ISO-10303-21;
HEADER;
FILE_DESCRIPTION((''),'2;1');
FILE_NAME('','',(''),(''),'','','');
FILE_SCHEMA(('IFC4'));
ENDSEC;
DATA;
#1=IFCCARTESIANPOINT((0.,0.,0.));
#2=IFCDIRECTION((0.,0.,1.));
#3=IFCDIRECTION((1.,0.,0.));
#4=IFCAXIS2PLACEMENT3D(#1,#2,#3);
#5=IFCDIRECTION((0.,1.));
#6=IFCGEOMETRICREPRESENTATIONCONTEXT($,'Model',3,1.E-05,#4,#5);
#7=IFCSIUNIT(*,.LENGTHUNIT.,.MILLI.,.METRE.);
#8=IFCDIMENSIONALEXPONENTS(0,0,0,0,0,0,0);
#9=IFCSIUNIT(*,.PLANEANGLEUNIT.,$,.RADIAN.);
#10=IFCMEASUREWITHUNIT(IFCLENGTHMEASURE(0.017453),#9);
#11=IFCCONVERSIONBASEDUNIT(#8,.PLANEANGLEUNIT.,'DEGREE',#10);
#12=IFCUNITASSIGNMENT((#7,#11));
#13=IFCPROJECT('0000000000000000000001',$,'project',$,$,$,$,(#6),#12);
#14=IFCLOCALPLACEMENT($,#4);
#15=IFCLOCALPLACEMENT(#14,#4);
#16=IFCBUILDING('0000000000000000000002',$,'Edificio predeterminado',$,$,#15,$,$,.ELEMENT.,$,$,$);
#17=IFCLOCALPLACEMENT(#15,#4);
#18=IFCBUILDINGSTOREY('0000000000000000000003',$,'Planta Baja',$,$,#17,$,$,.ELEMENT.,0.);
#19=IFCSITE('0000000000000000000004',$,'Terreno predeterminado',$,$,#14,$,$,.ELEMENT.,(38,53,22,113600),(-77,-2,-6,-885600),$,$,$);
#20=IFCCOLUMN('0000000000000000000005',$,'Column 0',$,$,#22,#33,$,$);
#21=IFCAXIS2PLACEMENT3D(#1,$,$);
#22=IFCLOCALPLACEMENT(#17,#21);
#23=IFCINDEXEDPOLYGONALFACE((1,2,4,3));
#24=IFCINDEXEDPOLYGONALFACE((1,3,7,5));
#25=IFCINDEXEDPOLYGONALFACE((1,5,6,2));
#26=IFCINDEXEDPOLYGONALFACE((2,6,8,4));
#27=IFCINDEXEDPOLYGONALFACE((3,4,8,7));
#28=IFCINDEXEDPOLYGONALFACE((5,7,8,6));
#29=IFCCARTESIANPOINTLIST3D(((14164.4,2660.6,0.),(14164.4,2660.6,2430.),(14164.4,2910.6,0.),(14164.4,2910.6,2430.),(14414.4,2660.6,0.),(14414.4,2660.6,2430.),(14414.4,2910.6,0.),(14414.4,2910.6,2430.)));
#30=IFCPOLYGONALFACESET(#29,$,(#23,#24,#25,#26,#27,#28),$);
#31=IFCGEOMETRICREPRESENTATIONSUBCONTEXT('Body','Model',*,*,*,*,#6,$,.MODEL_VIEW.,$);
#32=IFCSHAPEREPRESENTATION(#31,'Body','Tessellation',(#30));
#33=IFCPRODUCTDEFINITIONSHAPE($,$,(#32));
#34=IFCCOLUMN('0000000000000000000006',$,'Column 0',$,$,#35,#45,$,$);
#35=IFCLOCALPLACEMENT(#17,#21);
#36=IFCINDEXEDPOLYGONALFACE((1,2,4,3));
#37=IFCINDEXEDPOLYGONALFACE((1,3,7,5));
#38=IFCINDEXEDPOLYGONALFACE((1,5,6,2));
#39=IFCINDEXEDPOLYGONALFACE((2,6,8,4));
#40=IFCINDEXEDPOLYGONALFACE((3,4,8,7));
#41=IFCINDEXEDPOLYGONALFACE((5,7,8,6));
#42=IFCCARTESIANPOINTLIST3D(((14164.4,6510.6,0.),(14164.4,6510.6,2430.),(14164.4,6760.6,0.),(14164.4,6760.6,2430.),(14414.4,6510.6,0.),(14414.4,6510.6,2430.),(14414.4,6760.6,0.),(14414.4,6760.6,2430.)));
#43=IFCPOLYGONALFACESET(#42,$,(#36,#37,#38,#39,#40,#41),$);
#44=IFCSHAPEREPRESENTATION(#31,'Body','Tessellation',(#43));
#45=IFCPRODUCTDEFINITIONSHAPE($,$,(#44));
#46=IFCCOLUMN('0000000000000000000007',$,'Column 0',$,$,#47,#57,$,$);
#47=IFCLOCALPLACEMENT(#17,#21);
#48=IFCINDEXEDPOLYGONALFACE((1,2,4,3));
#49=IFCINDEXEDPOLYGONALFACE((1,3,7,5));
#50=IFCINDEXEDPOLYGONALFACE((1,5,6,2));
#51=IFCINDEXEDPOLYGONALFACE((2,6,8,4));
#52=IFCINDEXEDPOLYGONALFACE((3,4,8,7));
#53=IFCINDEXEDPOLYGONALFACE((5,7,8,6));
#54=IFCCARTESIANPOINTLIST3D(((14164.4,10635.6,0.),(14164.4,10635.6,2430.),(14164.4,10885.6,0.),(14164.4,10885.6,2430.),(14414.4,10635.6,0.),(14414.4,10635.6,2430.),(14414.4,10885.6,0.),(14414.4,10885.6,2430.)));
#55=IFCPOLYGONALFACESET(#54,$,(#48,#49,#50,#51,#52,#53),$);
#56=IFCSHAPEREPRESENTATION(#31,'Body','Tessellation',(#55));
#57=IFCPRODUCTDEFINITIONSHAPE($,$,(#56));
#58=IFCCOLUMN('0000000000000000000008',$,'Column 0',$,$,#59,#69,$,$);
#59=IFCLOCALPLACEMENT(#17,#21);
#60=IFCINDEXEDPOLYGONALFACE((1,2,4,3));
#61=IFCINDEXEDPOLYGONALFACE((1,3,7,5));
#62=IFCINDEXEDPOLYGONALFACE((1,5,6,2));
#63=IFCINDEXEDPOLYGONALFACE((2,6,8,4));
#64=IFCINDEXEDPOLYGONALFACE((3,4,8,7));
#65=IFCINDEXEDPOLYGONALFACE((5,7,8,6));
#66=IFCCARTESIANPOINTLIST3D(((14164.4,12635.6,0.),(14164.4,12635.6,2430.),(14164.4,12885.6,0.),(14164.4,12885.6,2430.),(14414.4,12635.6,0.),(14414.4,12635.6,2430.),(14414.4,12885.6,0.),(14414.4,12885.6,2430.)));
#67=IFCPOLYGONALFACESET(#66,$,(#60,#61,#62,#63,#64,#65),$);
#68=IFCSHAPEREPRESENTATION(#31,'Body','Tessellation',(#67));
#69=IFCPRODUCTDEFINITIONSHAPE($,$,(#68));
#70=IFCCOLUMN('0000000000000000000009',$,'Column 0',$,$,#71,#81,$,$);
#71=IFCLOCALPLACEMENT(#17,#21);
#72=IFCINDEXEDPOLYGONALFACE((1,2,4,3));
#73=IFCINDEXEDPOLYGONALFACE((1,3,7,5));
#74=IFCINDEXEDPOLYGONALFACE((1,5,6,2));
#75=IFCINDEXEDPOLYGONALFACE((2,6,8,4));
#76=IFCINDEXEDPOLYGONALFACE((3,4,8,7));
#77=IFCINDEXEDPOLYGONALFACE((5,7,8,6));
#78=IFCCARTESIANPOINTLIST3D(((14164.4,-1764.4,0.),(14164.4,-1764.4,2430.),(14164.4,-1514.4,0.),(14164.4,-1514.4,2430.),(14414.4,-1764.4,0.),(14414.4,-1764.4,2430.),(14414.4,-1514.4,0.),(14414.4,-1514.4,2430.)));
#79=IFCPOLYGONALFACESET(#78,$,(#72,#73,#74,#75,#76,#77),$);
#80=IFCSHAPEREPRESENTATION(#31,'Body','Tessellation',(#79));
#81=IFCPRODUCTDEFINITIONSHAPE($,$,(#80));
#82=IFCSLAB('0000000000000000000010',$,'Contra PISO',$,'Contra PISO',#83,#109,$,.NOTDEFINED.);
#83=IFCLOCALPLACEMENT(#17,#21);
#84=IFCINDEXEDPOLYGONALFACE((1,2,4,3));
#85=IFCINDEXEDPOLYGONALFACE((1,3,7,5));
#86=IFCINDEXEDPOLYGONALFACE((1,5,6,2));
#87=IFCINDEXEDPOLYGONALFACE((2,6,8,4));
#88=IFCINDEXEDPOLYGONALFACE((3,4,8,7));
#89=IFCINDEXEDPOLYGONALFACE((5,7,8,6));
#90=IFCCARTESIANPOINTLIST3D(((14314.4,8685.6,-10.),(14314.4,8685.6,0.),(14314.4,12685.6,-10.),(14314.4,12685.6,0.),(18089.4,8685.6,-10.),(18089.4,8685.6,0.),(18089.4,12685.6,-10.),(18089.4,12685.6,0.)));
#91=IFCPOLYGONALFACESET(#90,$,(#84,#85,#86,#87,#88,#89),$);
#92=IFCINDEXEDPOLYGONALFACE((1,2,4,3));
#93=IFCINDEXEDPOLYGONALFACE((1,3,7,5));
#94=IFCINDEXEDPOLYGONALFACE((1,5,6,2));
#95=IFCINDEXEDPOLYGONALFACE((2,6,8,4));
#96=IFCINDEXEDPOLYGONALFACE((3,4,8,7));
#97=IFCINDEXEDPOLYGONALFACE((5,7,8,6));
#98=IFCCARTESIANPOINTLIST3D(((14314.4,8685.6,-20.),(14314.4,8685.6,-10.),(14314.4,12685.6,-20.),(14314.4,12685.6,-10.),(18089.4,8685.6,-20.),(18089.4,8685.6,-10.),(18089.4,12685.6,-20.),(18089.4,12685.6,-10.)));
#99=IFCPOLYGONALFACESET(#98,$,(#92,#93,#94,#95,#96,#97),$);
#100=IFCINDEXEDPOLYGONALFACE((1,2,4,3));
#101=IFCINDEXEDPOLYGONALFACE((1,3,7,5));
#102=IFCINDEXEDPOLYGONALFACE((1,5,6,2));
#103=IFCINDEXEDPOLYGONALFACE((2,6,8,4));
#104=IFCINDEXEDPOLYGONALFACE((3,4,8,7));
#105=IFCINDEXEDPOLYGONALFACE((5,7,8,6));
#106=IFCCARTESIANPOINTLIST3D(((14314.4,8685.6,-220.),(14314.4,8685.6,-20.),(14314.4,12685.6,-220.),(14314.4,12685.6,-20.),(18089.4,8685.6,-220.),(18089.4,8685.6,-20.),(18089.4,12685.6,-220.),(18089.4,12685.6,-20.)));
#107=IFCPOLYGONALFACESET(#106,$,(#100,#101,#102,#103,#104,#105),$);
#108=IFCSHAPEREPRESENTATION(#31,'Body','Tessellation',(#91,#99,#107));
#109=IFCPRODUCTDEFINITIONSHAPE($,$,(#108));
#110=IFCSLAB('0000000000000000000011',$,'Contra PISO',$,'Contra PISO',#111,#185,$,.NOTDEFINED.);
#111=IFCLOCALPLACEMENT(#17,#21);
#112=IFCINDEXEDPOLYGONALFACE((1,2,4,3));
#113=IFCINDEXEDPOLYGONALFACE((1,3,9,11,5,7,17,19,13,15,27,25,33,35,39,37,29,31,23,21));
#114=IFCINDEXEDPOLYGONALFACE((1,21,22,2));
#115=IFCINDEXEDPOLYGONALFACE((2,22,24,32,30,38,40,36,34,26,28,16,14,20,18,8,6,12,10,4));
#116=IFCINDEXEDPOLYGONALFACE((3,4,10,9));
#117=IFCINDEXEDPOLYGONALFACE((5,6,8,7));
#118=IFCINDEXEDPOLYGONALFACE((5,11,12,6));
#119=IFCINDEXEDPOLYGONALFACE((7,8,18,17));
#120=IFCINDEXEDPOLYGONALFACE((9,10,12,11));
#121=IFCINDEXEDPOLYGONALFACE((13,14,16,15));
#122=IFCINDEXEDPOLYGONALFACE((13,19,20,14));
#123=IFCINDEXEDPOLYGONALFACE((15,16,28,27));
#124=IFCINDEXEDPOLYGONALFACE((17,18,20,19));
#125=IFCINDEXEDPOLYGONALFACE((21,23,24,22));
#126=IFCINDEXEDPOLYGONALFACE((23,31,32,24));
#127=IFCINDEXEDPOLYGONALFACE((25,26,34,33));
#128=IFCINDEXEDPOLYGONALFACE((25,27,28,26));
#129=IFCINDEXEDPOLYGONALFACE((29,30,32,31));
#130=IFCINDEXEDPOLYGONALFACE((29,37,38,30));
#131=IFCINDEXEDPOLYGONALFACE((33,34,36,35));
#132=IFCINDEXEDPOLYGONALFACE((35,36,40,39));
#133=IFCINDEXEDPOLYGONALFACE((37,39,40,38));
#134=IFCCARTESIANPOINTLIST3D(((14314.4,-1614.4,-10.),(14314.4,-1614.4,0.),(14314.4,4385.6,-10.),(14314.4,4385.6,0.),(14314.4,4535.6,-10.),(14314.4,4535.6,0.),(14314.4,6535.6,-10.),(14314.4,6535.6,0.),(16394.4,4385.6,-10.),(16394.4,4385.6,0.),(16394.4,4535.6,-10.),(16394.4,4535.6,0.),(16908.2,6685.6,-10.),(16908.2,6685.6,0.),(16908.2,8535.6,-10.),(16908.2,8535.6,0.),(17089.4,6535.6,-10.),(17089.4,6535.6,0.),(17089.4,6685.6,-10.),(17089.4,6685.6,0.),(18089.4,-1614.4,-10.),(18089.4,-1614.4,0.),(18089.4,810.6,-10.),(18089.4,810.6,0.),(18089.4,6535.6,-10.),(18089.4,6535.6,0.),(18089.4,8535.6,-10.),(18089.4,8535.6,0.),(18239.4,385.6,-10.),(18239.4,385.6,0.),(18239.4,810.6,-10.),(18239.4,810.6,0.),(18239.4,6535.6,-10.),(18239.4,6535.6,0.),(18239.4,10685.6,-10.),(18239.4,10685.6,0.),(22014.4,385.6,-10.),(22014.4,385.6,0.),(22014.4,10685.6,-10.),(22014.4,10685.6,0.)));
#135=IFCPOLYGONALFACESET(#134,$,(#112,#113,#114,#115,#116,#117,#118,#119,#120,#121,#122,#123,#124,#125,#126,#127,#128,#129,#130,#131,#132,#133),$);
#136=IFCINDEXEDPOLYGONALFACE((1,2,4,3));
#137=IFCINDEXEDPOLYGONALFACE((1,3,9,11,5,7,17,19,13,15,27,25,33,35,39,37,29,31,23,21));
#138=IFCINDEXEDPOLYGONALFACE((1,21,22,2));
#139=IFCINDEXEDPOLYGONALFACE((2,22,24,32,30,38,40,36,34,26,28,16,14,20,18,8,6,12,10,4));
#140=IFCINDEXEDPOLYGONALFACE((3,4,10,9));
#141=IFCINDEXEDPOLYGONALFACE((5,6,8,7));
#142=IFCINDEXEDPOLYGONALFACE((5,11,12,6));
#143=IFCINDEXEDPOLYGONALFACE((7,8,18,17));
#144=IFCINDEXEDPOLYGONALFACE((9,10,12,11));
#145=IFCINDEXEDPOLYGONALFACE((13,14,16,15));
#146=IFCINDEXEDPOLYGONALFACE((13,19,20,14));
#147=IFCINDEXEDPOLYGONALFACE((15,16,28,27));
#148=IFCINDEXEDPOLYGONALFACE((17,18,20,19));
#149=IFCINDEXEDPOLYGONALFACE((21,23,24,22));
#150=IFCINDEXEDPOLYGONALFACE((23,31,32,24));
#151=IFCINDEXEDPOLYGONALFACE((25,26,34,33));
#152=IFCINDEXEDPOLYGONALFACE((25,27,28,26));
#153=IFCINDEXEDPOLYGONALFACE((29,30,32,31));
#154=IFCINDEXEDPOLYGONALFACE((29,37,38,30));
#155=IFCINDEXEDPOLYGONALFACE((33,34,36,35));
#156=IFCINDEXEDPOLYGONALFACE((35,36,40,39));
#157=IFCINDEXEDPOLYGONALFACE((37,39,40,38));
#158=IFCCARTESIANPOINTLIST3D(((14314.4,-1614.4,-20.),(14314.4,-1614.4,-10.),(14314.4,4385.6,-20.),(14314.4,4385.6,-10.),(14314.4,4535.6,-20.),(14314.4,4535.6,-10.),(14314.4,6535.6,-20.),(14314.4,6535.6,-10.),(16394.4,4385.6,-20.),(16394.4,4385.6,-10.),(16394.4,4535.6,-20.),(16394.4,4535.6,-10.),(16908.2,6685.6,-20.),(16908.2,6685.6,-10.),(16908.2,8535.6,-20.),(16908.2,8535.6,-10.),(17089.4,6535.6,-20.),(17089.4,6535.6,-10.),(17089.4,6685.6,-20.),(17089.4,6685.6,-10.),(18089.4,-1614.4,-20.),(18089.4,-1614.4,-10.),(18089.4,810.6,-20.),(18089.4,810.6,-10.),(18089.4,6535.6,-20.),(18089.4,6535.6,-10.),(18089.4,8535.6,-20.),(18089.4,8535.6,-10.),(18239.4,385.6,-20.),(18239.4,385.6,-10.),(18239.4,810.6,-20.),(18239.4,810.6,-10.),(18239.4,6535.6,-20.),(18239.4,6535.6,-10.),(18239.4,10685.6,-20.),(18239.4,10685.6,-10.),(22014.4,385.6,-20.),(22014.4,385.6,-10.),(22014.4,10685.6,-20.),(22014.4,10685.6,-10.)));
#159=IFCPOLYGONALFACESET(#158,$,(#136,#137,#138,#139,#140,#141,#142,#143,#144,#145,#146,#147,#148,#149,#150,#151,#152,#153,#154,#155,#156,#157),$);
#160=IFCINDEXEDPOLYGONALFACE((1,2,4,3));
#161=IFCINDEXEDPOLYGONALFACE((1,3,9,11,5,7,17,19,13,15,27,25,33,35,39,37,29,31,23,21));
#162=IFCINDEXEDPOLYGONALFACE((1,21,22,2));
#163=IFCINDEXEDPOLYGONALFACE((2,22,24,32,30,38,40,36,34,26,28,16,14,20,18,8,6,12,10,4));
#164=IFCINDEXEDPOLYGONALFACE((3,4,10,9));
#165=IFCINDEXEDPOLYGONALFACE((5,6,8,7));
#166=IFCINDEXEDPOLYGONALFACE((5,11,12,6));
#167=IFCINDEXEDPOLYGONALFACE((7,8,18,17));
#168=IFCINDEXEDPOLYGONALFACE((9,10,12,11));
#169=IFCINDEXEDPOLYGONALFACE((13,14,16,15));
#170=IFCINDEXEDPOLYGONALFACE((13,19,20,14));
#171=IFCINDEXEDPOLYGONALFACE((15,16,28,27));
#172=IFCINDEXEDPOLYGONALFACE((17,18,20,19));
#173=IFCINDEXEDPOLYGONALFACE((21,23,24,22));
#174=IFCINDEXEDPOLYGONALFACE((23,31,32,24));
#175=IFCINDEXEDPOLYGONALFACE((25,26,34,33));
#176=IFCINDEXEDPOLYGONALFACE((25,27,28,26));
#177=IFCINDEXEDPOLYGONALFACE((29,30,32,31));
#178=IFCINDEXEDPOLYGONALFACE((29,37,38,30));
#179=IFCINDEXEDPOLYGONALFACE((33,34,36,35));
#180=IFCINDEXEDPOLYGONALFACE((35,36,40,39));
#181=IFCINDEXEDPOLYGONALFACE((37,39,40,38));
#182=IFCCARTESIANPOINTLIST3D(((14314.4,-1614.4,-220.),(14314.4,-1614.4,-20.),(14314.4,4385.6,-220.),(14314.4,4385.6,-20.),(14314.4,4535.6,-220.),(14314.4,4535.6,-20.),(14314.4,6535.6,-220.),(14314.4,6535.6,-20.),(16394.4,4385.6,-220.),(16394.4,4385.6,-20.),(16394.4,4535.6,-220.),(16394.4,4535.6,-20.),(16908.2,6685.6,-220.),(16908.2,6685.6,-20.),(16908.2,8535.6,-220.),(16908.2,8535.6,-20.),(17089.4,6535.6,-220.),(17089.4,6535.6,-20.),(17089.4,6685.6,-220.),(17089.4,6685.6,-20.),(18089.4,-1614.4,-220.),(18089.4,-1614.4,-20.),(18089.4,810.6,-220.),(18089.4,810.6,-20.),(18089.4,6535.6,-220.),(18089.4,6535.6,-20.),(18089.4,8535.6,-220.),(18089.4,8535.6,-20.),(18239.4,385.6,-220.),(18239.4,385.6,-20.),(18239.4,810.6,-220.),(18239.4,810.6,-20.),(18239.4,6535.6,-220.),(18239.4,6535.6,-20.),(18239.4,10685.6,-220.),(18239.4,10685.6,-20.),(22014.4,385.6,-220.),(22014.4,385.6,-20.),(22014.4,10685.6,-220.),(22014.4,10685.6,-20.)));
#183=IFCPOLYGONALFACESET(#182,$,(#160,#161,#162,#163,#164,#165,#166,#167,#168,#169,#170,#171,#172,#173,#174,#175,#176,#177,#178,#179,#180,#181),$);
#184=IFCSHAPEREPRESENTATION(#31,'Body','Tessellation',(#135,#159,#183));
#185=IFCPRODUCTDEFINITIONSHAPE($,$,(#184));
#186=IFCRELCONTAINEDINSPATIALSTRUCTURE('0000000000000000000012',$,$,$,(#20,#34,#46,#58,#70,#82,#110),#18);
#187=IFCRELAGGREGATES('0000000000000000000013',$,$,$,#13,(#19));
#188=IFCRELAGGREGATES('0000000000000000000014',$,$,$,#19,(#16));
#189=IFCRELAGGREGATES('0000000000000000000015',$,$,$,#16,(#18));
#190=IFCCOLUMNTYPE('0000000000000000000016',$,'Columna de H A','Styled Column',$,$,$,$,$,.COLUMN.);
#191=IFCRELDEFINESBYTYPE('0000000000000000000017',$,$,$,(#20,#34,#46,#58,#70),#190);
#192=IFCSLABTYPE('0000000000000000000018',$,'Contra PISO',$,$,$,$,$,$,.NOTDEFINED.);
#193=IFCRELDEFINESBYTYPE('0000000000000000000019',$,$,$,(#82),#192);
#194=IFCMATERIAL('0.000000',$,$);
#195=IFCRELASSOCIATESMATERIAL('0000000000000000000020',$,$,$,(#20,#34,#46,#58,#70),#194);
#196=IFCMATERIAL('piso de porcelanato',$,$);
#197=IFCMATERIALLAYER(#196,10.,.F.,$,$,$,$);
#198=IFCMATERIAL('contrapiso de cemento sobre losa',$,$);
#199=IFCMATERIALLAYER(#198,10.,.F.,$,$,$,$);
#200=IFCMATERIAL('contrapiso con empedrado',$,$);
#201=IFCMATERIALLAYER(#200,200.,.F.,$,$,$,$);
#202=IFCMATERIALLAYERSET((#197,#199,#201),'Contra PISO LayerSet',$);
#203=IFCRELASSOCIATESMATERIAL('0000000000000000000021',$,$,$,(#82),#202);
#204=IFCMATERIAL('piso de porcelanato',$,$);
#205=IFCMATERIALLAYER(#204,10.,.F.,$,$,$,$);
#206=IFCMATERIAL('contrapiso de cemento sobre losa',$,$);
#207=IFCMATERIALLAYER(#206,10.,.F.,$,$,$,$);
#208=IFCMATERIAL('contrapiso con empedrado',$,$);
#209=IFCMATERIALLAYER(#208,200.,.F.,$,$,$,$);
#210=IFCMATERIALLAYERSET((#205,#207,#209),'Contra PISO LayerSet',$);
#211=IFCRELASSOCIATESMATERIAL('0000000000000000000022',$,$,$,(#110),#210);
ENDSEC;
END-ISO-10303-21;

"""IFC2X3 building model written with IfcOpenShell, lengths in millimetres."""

from ifc_helpers import new_model, entity, si_unit, converted_unit, direction, frame, origin_with_axes, place, context, subcontext, project, spatial, polyline, outline, extrude, material, layer, layer_set, layer_usage, type_object, element, save


model = new_model("IFC2X3")

# Units and contexts
model_context = context("Model", 3, precision=1e-05, world=origin_with_axes(), true_north=direction((0.0, 1.0)))
body_context = subcontext(model_context, "Body", "Model", "MODEL_VIEW")
ifc_project = project(units=[si_unit("LENGTHUNIT", "METRE", prefix="MILLI"), converted_unit("PLANEANGLEUNIT", "DEGREE", entity("IfcLengthMeasure", 0.017453), si_unit("PLANEANGLEUNIT", "RADIAN"), dimensions=[0, 0, 0, 0, 0, 0, 0])], contexts=[model_context])

# Site, building, storey
site_placement = place(None, origin_with_axes())
site = spatial("IfcSite", under=ifc_project, at=site_placement, Name="Terreno predeterminado", CompositionType="ELEMENT", RefLatitude=(38, 53, 22, 113600), RefLongitude=(-77, -2, -6, -885600))
building_placement = place(site_placement, origin_with_axes())
building = spatial("IfcBuilding", under=site, at=building_placement, Name="Edificio predeterminado", CompositionType="ELEMENT")
storey_placement = place(building_placement, origin_with_axes())
storey = spatial("IfcBuildingStorey", under=building, at=storey_placement, Name="Planta Baja", CompositionType="ELEMENT", Elevation=0.0)

# Columns
ifc_material_1 = material(Name="0.000000")
column_type = type_object("IfcColumnType", Name="Columna de H A", Description="Styled Column", PredefinedType="COLUMN")
for number, where, z_axis, x_axis, name in (
    (1, (14289.4, 2785.6, 0.0), (0.0, 0.0, 1.0), (1.0, 0.0, 0.0), "Column 0"),
    (2, (14289.4, 6635.6, 0.0), (0.0, 0.0, 1.0), (1.0, 0.0, 0.0), "Column 0"),
    (3, (14289.4, 10760.6, 0.0), (0.0, 0.0, 1.0), (1.0, 0.0, 0.0), "Column 0"),
    (4, (14289.4, 12760.6, 0.0), (0.0, 0.0, 1.0), (1.0, 0.0, 0.0), "Column 0"),
    (5, (14289.4, -1639.4, 0.0), (0.0, 0.0, 1.0), (1.0, 0.0, 0.0), "Column 0"),
):
    element("IfcColumn", number, at=place(storey_placement, frame(where, z_axis=z_axis, x_axis=x_axis)), inside=storey, type_object=column_type, material=ifc_material_1, Name=name, context=body_context, shape_type="SweptSolid", body=[
        extrude(outline(polyline([(-125.0, -125.0), (125.0, -125.0), (125.0, 125.0), (-125.0, 125.0), (-125.0, -125.0)])), origin_with_axes(), (0.0, 0.0, 1.0), 2430.0),
    ])

# Slabs
ifc_material_2 = material(Name="piso de porcelanato")
ifc_layer_1 = layer(ifc_material_2, 10.0, ventilated=False)
ifc_material_3 = material(Name="contrapiso de cemento sobre losa")
ifc_layer_2 = layer(ifc_material_3, 10.0, ventilated=False)
ifc_material_4 = material(Name="contrapiso con empedrado")
ifc_layer_3 = layer(ifc_material_4, 200.0, ventilated=False)
ifc_layer_set_1 = layer_set([ifc_layer_1, ifc_layer_2, ifc_layer_3], Name="Contra PISO LayerSet")
ifc_layer_usage_1 = layer_usage(ifc_layer_set_1, "AXIS3", "NEGATIVE", 0.0)
slab_type = type_object("IfcSlabType", Name="Contra PISO", PredefinedType="NOTDEFINED")
slab_1_placement = place(storey_placement, origin_with_axes())
element("IfcSlab", 6, at=slab_1_placement, inside=storey, type_object=slab_type, material=ifc_layer_usage_1, Name="Contra PISO", ObjectType="Contra PISO", PredefinedType="NOTDEFINED", context=body_context, shape_type="SweptSolid", body=[
    extrude(outline(polyline([(0.0, 4000.0), (3775.0, 4000.0), (3775.0, 0.0), (0.0, 0.0), (0.0, 4000.0)])), frame((14314.4, 12685.6, -10.0), z_axis=(0.0, 0.0, -1.0), x_axis=(1.0, 0.0, 0.0)), (0.0, 0.0, -1.0), 10.0),
    extrude(outline(polyline([(0.0, 4000.0), (3775.0, 4000.0), (3775.0, 0.0), (0.0, 0.0), (0.0, 4000.0)])), frame((14314.4, 12685.6, -20.0), z_axis=(0.0, 0.0, -1.0), x_axis=(1.0, 0.0, 0.0)), (0.0, 0.0, -1.0), 10.0),
    extrude(outline(polyline([(0.0, 4000.0), (3775.0, 4000.0), (3775.0, 0.0), (0.0, 0.0), (0.0, 4000.0)])), frame((14314.4, 12685.6, -220.0), z_axis=(0.0, 0.0, -1.0), x_axis=(1.0, 0.0, 0.0)), (0.0, 0.0, -1.0), 200.0),
])
ifc_material_5 = material(Name="piso de porcelanato")
ifc_layer_4 = layer(ifc_material_5, 10.0, ventilated=False)
ifc_material_6 = material(Name="contrapiso de cemento sobre losa")
ifc_layer_5 = layer(ifc_material_6, 10.0, ventilated=False)
ifc_material_7 = material(Name="contrapiso con empedrado")
ifc_layer_6 = layer(ifc_material_7, 200.0, ventilated=False)
ifc_layer_set_2 = layer_set([ifc_layer_4, ifc_layer_5, ifc_layer_6], Name="Contra PISO LayerSet")
ifc_layer_usage_2 = layer_usage(ifc_layer_set_2, "AXIS3", "POSITIVE", 0.0)
slab_2_placement = place(storey_placement, origin_with_axes())
element("IfcSlab", 7, at=slab_2_placement, inside=storey, material=ifc_layer_usage_2, Name="Contra PISO", ObjectType="Contra PISO", PredefinedType="NOTDEFINED", context=body_context, shape_type="SweptSolid", body=[
    extrude(outline(polyline([(0.0, -6000.0), (3775.0, -6000.0), (3775.0, -3575.0), (3925.0, -3575.0), (3925.0, -4000.0), (7700.0, -4000.0), (7700.0, 6300.0), (3925.0, 6300.0), (3925.0, 2150.0), (3775.0, 2150.0), (3775.0, 4150.0), (2593.9, 4150.0), (2593.9, 2300.0), (2775.0, 2300.0), (2775.0, 2150.0), (0.0, 2150.0), (0.0, 150.0), (2080.0, 150.0), (2080.0, 0.0), (0.0, 0.0), (0.0, -6000.0)])), frame((14314.4, 4385.6, -10.0), z_axis=(0.0, 0.0, 1.0), x_axis=(1.0, 0.0, 0.0)), (0.0, 0.0, 1.0), 10.0),
    extrude(outline(polyline([(0.0, -6000.0), (3775.0, -6000.0), (3775.0, -3575.0), (3925.0, -3575.0), (3925.0, -4000.0), (7700.0, -4000.0), (7700.0, 6300.0), (3925.0, 6300.0), (3925.0, 2150.0), (3775.0, 2150.0), (3775.0, 4150.0), (2593.9, 4150.0), (2593.9, 2300.0), (2775.0, 2300.0), (2775.0, 2150.0), (0.0, 2150.0), (0.0, 150.0), (2080.0, 150.0), (2080.0, 0.0), (0.0, 0.0), (0.0, -6000.0)])), frame((14314.4, 4385.6, -20.0), z_axis=(0.0, 0.0, 1.0), x_axis=(1.0, 0.0, 0.0)), (0.0, 0.0, 1.0), 10.0),
    extrude(outline(polyline([(0.0, -6000.0), (3775.0, -6000.0), (3775.0, -3575.0), (3925.0, -3575.0), (3925.0, -4000.0), (7700.0, -4000.0), (7700.0, 6300.0), (3925.0, 6300.0), (3925.0, 2150.0), (3775.0, 2150.0), (3775.0, 4150.0), (2593.9, 4150.0), (2593.9, 2300.0), (2775.0, 2300.0), (2775.0, 2150.0), (0.0, 2150.0), (0.0, 150.0), (2080.0, 150.0), (2080.0, 0.0), (0.0, 0.0), (0.0, -6000.0)])), frame((14314.4, 4385.6, -220.0), z_axis=(0.0, 0.0, 1.0), x_axis=(1.0, 0.0, 0.0)), (0.0, 0.0, 1.0), 200.0),
])

save(model, "model.ifc")
